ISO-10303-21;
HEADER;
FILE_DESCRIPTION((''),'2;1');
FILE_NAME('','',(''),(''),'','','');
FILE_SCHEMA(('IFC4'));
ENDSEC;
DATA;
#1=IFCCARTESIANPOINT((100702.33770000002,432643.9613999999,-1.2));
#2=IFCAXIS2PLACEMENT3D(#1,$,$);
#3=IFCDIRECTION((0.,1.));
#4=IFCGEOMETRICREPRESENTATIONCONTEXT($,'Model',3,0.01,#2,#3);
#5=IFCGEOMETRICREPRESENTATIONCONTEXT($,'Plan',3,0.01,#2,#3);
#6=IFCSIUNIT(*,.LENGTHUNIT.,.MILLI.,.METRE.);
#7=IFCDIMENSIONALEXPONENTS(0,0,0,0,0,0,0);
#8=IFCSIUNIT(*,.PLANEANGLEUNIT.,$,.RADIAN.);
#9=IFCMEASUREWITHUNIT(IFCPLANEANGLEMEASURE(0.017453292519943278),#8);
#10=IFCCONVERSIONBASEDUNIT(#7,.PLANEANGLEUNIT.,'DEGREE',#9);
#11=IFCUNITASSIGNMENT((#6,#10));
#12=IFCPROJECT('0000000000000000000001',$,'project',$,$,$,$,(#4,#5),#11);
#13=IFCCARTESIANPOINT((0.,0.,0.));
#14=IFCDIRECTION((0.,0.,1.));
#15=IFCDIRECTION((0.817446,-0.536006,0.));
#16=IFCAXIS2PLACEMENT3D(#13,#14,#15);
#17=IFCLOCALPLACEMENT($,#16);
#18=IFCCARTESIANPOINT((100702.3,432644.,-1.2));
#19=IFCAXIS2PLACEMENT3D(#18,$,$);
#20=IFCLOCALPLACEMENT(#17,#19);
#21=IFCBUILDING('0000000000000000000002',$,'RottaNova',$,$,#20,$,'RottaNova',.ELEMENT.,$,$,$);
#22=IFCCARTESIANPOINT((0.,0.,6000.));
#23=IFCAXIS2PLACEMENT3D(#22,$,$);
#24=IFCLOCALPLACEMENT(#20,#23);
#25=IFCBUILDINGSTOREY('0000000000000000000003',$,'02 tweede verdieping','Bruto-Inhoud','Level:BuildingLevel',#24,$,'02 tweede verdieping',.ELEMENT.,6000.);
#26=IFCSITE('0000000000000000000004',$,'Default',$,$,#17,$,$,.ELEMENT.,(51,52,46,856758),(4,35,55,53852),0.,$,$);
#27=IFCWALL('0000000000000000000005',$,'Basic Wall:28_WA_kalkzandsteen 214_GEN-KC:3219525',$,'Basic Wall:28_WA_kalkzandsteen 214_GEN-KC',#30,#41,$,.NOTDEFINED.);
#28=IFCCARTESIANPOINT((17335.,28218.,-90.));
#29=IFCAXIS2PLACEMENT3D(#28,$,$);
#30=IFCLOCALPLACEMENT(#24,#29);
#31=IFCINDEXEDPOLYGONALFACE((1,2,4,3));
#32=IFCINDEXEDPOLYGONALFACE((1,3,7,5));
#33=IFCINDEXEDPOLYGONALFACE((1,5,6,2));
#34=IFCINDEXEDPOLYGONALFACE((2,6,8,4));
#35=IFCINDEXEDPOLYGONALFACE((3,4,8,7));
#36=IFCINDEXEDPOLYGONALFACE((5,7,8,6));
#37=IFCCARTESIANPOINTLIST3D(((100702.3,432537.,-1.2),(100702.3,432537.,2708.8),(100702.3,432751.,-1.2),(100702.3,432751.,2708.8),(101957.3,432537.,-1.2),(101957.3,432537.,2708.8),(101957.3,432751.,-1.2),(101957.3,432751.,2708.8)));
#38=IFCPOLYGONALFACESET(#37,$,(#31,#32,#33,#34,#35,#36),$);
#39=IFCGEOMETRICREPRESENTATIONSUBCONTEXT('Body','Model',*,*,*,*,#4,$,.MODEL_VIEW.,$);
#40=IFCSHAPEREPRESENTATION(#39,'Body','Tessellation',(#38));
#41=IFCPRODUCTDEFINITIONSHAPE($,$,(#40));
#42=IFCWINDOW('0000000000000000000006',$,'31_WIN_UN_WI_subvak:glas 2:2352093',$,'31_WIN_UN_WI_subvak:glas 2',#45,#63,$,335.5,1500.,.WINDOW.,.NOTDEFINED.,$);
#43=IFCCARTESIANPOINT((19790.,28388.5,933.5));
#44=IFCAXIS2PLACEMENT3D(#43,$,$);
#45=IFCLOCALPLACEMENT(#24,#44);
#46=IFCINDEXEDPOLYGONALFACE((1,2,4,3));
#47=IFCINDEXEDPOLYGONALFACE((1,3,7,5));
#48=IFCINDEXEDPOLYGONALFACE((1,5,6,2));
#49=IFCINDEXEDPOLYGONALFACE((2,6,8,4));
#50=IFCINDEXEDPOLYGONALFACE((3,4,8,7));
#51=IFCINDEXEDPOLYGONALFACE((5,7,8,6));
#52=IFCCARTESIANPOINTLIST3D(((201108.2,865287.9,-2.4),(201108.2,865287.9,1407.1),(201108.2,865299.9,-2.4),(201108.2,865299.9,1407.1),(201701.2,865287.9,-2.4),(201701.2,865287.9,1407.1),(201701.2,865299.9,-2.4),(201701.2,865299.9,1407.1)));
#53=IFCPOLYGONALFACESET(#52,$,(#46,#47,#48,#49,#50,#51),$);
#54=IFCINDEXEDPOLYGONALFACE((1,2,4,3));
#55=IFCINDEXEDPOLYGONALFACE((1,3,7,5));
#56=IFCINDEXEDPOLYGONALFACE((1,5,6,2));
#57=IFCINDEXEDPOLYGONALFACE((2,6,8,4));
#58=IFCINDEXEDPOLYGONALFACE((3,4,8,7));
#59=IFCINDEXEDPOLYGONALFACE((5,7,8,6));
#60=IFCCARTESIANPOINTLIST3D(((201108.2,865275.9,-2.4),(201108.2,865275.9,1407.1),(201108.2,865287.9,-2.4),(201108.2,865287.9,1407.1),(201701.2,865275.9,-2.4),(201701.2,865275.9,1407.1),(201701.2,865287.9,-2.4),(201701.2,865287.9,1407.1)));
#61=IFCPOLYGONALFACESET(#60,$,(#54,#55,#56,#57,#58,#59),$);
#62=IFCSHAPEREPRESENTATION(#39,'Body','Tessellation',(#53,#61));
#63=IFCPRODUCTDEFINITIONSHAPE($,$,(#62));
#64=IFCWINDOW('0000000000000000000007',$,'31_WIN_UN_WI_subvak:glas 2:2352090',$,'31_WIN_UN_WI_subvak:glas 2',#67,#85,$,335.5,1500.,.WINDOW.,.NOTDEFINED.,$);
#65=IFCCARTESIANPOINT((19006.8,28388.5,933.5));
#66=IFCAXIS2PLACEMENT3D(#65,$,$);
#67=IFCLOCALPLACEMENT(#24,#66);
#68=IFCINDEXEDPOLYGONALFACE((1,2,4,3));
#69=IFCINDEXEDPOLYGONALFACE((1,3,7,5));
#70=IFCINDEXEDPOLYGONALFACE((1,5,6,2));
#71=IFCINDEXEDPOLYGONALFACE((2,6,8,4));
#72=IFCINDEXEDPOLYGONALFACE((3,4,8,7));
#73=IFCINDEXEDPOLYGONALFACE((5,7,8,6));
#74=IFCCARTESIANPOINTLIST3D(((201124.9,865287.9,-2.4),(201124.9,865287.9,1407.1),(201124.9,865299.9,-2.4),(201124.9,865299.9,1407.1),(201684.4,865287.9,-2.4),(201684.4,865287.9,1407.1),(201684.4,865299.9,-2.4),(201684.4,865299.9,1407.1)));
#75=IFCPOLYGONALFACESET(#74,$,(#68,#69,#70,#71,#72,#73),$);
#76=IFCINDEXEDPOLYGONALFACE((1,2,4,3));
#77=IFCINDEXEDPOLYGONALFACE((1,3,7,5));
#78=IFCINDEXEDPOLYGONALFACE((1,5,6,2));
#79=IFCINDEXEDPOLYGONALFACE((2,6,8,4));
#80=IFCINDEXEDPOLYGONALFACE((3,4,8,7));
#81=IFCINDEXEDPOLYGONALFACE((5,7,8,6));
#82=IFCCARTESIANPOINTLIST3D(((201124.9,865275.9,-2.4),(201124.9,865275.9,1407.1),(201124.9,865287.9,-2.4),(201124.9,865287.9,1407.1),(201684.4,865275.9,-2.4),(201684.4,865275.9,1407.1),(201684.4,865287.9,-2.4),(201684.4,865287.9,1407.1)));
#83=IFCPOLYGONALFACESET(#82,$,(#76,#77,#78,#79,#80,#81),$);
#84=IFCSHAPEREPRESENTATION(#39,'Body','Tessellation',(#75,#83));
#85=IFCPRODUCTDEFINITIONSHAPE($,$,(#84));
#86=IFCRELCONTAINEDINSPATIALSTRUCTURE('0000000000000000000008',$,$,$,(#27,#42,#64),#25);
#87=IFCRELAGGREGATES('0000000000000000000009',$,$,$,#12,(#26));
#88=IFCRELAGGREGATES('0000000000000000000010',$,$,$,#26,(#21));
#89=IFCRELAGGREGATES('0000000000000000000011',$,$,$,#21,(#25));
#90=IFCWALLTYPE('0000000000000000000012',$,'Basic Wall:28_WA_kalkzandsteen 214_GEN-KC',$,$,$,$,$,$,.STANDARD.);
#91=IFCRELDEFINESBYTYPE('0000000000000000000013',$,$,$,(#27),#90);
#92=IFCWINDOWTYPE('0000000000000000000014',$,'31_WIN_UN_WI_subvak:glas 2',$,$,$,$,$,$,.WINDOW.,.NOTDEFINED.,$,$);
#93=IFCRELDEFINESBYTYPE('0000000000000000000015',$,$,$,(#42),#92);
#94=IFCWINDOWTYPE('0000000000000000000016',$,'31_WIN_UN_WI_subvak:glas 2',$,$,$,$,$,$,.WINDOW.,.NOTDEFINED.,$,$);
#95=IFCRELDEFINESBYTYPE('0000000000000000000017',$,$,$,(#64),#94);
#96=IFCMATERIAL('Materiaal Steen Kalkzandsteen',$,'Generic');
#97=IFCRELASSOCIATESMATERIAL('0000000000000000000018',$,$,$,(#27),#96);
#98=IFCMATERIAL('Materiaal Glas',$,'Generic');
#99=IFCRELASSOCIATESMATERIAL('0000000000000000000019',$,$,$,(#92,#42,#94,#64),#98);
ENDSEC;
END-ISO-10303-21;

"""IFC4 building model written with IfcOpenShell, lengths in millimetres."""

from ifc_helpers import new_model, entity, si_unit, converted_unit, direction, frame, place, context, subcontext, project, spatial, indexed_curve, outline, extrude, source, transform, mapped, material, type_object, type_shapes, element, save


model = new_model("IFC4")

# Units and contexts
model_context = context("Model", 3, precision=0.01, world=frame((100702.33770000002, 432643.9613999999, -1.2)), true_north=direction((0.0, 1.0)))
plan_context = context("Plan", 3, precision=0.01, world=frame((100702.33770000002, 432643.9613999999, -1.2)), true_north=direction((0.0, 1.0)))
body_context = subcontext(model_context, "Body", "Model", "MODEL_VIEW")
ifc_project = project(units=[si_unit("LENGTHUNIT", "METRE", prefix="MILLI"), converted_unit("PLANEANGLEUNIT", "DEGREE", entity("IfcPlaneAngleMeasure", 0.017453292519943278), si_unit("PLANEANGLEUNIT", "RADIAN"), dimensions=[0, 0, 0, 0, 0, 0, 0])], contexts=[model_context, plan_context])

# Site, building, storey
site_placement = place(None, frame((0.0, 0.0, 0.0), z_axis=(0.0, 0.0, 1.0), x_axis=(0.817446, -0.536006, 0.0)))
site = spatial("IfcSite", under=ifc_project, at=site_placement, Name="Default", CompositionType="ELEMENT", RefLatitude=(51, 52, 46, 856758), RefLongitude=(4, 35, 55, 53852), RefElevation=0.0)
building_placement = place(site_placement, frame((100702.3, 432644.0, -1.2)))
building = spatial("IfcBuilding", under=site, at=building_placement, Name="RottaNova", LongName="RottaNova", CompositionType="ELEMENT")
storey_placement = place(building_placement, frame((0.0, 0.0, 6000.0)))
storey = spatial("IfcBuildingStorey", under=building, at=storey_placement, Name="02 tweede verdieping", Description="Bruto-Inhoud", ObjectType="Level:BuildingLevel", LongName="02 tweede verdieping", CompositionType="ELEMENT", Elevation=6000.0)

# Shared definitions
ifc_material_1 = material(Name="Materiaal Glas", Category="Generic")

# Wall
ifc_material_2 = material(Name="Materiaal Steen Kalkzandsteen", Category="Generic")
wall_type = type_object("IfcWallType", Name="Basic Wall:28_WA_kalkzandsteen 214_GEN-KC", PredefinedType="STANDARD")
wall_placement = place(storey_placement, frame((17335.0, 28218.0, -90.0)))
element("IfcWall", 1, at=wall_placement, inside=storey, type_object=wall_type, material=ifc_material_2, Name="Basic Wall:28_WA_kalkzandsteen 214_GEN-KC:3219525", ObjectType="Basic Wall:28_WA_kalkzandsteen 214_GEN-KC", PredefinedType="NOTDEFINED", context=body_context, shape_type="SweptSolid", body=[
    extrude(outline(indexed_curve([(1255.0, 107.0), (0.0, 107.0), (0.0, -107.0), (1255.0, -107.0), (1255.0, 107.0)], self_intersect=False)), frame((100702.3, 432644.0, -1.2)), (0.0, 0.0, 1.0), 2710.0),
])

# Windows
window_type_1 = type_object("IfcWindowType", Name="31_WIN_UN_WI_subvak:glas 2", PartitioningType="NOTDEFINED", PredefinedType="WINDOW", material=ifc_material_1)
shared_shape_1 = source(frame((100702.3, 432644.0, -1.2)), body_context, "Body", "SweptSolid", [
    extrude(outline(indexed_curve([(-6.0, -296.5), (6.0, -296.5), (6.0, 296.5), (-6.0, 296.5), (-6.0, -296.5)], self_intersect=False)), frame((0.0, 6.0, 0.0), z_axis=(0.0, 0.0, 1.0), x_axis=(0.0, -1.0, 0.0)), (0.0, 0.0, 1.0), 1409.5),
    extrude(outline(indexed_curve([(-6.0, -296.5), (6.0, -296.5), (6.0, 296.5), (-6.0, 296.5), (-6.0, -296.5)], self_intersect=False)), frame((0.0, -6.0, 0.0), z_axis=(0.0, 0.0, 1.0), x_axis=(0.0, -1.0, 0.0)), (0.0, 0.0, 1.0), 1409.5),
])
type_shapes(window_type_1, [shared_shape_1])
window_1_placement = place(storey_placement, frame((19790.0, 28388.5, 933.5)))
element("IfcWindow", 2, at=window_1_placement, inside=storey, type_object=window_type_1, material=ifc_material_1, Name="31_WIN_UN_WI_subvak:glas 2:2352093", ObjectType="31_WIN_UN_WI_subvak:glas 2", OverallHeight=335.5, OverallWidth=1500.0, PartitioningType="NOTDEFINED", PredefinedType="WINDOW", context=body_context, shape_type="MappedRepresentation", body=[
    mapped(shared_shape_1, transform((100702.3, 432644.0, -1.2), scale=1.0)),
])
window_type_2 = type_object("IfcWindowType", Name="31_WIN_UN_WI_subvak:glas 2", PartitioningType="NOTDEFINED", PredefinedType="WINDOW", material=ifc_material_1)
shared_shape_2 = source(frame((100702.3, 432644.0, -1.2)), body_context, "Body", "SweptSolid", [
    extrude(outline(indexed_curve([(-6.0, -279.8), (6.0, -279.8), (6.0, 279.8), (-6.0, 279.8), (-6.0, -279.8)], self_intersect=False)), frame((0.0, 6.0, 0.0), z_axis=(0.0, 0.0, 1.0), x_axis=(0.0, -1.0, 0.0)), (0.0, 0.0, 1.0), 1409.5),
    extrude(outline(indexed_curve([(-6.0, -279.8), (6.0, -279.8), (6.0, 279.8), (-6.0, 279.8), (-6.0, -279.8)], self_intersect=False)), frame((0.0, -6.0, 0.0), z_axis=(0.0, 0.0, 1.0), x_axis=(0.0, -1.0, 0.0)), (0.0, 0.0, 1.0), 1409.5),
])
type_shapes(window_type_2, [shared_shape_2])
window_2_placement = place(storey_placement, frame((19006.8, 28388.5, 933.5)))
element("IfcWindow", 3, at=window_2_placement, inside=storey, type_object=window_type_2, material=ifc_material_1, Name="31_WIN_UN_WI_subvak:glas 2:2352090", ObjectType="31_WIN_UN_WI_subvak:glas 2", OverallHeight=335.5, OverallWidth=1500.0, PartitioningType="NOTDEFINED", PredefinedType="WINDOW", context=body_context, shape_type="MappedRepresentation", body=[
    mapped(shared_shape_2, transform((100702.3, 432644.0, -1.2), scale=1.0)),
])

save(model, "model.ifc")
